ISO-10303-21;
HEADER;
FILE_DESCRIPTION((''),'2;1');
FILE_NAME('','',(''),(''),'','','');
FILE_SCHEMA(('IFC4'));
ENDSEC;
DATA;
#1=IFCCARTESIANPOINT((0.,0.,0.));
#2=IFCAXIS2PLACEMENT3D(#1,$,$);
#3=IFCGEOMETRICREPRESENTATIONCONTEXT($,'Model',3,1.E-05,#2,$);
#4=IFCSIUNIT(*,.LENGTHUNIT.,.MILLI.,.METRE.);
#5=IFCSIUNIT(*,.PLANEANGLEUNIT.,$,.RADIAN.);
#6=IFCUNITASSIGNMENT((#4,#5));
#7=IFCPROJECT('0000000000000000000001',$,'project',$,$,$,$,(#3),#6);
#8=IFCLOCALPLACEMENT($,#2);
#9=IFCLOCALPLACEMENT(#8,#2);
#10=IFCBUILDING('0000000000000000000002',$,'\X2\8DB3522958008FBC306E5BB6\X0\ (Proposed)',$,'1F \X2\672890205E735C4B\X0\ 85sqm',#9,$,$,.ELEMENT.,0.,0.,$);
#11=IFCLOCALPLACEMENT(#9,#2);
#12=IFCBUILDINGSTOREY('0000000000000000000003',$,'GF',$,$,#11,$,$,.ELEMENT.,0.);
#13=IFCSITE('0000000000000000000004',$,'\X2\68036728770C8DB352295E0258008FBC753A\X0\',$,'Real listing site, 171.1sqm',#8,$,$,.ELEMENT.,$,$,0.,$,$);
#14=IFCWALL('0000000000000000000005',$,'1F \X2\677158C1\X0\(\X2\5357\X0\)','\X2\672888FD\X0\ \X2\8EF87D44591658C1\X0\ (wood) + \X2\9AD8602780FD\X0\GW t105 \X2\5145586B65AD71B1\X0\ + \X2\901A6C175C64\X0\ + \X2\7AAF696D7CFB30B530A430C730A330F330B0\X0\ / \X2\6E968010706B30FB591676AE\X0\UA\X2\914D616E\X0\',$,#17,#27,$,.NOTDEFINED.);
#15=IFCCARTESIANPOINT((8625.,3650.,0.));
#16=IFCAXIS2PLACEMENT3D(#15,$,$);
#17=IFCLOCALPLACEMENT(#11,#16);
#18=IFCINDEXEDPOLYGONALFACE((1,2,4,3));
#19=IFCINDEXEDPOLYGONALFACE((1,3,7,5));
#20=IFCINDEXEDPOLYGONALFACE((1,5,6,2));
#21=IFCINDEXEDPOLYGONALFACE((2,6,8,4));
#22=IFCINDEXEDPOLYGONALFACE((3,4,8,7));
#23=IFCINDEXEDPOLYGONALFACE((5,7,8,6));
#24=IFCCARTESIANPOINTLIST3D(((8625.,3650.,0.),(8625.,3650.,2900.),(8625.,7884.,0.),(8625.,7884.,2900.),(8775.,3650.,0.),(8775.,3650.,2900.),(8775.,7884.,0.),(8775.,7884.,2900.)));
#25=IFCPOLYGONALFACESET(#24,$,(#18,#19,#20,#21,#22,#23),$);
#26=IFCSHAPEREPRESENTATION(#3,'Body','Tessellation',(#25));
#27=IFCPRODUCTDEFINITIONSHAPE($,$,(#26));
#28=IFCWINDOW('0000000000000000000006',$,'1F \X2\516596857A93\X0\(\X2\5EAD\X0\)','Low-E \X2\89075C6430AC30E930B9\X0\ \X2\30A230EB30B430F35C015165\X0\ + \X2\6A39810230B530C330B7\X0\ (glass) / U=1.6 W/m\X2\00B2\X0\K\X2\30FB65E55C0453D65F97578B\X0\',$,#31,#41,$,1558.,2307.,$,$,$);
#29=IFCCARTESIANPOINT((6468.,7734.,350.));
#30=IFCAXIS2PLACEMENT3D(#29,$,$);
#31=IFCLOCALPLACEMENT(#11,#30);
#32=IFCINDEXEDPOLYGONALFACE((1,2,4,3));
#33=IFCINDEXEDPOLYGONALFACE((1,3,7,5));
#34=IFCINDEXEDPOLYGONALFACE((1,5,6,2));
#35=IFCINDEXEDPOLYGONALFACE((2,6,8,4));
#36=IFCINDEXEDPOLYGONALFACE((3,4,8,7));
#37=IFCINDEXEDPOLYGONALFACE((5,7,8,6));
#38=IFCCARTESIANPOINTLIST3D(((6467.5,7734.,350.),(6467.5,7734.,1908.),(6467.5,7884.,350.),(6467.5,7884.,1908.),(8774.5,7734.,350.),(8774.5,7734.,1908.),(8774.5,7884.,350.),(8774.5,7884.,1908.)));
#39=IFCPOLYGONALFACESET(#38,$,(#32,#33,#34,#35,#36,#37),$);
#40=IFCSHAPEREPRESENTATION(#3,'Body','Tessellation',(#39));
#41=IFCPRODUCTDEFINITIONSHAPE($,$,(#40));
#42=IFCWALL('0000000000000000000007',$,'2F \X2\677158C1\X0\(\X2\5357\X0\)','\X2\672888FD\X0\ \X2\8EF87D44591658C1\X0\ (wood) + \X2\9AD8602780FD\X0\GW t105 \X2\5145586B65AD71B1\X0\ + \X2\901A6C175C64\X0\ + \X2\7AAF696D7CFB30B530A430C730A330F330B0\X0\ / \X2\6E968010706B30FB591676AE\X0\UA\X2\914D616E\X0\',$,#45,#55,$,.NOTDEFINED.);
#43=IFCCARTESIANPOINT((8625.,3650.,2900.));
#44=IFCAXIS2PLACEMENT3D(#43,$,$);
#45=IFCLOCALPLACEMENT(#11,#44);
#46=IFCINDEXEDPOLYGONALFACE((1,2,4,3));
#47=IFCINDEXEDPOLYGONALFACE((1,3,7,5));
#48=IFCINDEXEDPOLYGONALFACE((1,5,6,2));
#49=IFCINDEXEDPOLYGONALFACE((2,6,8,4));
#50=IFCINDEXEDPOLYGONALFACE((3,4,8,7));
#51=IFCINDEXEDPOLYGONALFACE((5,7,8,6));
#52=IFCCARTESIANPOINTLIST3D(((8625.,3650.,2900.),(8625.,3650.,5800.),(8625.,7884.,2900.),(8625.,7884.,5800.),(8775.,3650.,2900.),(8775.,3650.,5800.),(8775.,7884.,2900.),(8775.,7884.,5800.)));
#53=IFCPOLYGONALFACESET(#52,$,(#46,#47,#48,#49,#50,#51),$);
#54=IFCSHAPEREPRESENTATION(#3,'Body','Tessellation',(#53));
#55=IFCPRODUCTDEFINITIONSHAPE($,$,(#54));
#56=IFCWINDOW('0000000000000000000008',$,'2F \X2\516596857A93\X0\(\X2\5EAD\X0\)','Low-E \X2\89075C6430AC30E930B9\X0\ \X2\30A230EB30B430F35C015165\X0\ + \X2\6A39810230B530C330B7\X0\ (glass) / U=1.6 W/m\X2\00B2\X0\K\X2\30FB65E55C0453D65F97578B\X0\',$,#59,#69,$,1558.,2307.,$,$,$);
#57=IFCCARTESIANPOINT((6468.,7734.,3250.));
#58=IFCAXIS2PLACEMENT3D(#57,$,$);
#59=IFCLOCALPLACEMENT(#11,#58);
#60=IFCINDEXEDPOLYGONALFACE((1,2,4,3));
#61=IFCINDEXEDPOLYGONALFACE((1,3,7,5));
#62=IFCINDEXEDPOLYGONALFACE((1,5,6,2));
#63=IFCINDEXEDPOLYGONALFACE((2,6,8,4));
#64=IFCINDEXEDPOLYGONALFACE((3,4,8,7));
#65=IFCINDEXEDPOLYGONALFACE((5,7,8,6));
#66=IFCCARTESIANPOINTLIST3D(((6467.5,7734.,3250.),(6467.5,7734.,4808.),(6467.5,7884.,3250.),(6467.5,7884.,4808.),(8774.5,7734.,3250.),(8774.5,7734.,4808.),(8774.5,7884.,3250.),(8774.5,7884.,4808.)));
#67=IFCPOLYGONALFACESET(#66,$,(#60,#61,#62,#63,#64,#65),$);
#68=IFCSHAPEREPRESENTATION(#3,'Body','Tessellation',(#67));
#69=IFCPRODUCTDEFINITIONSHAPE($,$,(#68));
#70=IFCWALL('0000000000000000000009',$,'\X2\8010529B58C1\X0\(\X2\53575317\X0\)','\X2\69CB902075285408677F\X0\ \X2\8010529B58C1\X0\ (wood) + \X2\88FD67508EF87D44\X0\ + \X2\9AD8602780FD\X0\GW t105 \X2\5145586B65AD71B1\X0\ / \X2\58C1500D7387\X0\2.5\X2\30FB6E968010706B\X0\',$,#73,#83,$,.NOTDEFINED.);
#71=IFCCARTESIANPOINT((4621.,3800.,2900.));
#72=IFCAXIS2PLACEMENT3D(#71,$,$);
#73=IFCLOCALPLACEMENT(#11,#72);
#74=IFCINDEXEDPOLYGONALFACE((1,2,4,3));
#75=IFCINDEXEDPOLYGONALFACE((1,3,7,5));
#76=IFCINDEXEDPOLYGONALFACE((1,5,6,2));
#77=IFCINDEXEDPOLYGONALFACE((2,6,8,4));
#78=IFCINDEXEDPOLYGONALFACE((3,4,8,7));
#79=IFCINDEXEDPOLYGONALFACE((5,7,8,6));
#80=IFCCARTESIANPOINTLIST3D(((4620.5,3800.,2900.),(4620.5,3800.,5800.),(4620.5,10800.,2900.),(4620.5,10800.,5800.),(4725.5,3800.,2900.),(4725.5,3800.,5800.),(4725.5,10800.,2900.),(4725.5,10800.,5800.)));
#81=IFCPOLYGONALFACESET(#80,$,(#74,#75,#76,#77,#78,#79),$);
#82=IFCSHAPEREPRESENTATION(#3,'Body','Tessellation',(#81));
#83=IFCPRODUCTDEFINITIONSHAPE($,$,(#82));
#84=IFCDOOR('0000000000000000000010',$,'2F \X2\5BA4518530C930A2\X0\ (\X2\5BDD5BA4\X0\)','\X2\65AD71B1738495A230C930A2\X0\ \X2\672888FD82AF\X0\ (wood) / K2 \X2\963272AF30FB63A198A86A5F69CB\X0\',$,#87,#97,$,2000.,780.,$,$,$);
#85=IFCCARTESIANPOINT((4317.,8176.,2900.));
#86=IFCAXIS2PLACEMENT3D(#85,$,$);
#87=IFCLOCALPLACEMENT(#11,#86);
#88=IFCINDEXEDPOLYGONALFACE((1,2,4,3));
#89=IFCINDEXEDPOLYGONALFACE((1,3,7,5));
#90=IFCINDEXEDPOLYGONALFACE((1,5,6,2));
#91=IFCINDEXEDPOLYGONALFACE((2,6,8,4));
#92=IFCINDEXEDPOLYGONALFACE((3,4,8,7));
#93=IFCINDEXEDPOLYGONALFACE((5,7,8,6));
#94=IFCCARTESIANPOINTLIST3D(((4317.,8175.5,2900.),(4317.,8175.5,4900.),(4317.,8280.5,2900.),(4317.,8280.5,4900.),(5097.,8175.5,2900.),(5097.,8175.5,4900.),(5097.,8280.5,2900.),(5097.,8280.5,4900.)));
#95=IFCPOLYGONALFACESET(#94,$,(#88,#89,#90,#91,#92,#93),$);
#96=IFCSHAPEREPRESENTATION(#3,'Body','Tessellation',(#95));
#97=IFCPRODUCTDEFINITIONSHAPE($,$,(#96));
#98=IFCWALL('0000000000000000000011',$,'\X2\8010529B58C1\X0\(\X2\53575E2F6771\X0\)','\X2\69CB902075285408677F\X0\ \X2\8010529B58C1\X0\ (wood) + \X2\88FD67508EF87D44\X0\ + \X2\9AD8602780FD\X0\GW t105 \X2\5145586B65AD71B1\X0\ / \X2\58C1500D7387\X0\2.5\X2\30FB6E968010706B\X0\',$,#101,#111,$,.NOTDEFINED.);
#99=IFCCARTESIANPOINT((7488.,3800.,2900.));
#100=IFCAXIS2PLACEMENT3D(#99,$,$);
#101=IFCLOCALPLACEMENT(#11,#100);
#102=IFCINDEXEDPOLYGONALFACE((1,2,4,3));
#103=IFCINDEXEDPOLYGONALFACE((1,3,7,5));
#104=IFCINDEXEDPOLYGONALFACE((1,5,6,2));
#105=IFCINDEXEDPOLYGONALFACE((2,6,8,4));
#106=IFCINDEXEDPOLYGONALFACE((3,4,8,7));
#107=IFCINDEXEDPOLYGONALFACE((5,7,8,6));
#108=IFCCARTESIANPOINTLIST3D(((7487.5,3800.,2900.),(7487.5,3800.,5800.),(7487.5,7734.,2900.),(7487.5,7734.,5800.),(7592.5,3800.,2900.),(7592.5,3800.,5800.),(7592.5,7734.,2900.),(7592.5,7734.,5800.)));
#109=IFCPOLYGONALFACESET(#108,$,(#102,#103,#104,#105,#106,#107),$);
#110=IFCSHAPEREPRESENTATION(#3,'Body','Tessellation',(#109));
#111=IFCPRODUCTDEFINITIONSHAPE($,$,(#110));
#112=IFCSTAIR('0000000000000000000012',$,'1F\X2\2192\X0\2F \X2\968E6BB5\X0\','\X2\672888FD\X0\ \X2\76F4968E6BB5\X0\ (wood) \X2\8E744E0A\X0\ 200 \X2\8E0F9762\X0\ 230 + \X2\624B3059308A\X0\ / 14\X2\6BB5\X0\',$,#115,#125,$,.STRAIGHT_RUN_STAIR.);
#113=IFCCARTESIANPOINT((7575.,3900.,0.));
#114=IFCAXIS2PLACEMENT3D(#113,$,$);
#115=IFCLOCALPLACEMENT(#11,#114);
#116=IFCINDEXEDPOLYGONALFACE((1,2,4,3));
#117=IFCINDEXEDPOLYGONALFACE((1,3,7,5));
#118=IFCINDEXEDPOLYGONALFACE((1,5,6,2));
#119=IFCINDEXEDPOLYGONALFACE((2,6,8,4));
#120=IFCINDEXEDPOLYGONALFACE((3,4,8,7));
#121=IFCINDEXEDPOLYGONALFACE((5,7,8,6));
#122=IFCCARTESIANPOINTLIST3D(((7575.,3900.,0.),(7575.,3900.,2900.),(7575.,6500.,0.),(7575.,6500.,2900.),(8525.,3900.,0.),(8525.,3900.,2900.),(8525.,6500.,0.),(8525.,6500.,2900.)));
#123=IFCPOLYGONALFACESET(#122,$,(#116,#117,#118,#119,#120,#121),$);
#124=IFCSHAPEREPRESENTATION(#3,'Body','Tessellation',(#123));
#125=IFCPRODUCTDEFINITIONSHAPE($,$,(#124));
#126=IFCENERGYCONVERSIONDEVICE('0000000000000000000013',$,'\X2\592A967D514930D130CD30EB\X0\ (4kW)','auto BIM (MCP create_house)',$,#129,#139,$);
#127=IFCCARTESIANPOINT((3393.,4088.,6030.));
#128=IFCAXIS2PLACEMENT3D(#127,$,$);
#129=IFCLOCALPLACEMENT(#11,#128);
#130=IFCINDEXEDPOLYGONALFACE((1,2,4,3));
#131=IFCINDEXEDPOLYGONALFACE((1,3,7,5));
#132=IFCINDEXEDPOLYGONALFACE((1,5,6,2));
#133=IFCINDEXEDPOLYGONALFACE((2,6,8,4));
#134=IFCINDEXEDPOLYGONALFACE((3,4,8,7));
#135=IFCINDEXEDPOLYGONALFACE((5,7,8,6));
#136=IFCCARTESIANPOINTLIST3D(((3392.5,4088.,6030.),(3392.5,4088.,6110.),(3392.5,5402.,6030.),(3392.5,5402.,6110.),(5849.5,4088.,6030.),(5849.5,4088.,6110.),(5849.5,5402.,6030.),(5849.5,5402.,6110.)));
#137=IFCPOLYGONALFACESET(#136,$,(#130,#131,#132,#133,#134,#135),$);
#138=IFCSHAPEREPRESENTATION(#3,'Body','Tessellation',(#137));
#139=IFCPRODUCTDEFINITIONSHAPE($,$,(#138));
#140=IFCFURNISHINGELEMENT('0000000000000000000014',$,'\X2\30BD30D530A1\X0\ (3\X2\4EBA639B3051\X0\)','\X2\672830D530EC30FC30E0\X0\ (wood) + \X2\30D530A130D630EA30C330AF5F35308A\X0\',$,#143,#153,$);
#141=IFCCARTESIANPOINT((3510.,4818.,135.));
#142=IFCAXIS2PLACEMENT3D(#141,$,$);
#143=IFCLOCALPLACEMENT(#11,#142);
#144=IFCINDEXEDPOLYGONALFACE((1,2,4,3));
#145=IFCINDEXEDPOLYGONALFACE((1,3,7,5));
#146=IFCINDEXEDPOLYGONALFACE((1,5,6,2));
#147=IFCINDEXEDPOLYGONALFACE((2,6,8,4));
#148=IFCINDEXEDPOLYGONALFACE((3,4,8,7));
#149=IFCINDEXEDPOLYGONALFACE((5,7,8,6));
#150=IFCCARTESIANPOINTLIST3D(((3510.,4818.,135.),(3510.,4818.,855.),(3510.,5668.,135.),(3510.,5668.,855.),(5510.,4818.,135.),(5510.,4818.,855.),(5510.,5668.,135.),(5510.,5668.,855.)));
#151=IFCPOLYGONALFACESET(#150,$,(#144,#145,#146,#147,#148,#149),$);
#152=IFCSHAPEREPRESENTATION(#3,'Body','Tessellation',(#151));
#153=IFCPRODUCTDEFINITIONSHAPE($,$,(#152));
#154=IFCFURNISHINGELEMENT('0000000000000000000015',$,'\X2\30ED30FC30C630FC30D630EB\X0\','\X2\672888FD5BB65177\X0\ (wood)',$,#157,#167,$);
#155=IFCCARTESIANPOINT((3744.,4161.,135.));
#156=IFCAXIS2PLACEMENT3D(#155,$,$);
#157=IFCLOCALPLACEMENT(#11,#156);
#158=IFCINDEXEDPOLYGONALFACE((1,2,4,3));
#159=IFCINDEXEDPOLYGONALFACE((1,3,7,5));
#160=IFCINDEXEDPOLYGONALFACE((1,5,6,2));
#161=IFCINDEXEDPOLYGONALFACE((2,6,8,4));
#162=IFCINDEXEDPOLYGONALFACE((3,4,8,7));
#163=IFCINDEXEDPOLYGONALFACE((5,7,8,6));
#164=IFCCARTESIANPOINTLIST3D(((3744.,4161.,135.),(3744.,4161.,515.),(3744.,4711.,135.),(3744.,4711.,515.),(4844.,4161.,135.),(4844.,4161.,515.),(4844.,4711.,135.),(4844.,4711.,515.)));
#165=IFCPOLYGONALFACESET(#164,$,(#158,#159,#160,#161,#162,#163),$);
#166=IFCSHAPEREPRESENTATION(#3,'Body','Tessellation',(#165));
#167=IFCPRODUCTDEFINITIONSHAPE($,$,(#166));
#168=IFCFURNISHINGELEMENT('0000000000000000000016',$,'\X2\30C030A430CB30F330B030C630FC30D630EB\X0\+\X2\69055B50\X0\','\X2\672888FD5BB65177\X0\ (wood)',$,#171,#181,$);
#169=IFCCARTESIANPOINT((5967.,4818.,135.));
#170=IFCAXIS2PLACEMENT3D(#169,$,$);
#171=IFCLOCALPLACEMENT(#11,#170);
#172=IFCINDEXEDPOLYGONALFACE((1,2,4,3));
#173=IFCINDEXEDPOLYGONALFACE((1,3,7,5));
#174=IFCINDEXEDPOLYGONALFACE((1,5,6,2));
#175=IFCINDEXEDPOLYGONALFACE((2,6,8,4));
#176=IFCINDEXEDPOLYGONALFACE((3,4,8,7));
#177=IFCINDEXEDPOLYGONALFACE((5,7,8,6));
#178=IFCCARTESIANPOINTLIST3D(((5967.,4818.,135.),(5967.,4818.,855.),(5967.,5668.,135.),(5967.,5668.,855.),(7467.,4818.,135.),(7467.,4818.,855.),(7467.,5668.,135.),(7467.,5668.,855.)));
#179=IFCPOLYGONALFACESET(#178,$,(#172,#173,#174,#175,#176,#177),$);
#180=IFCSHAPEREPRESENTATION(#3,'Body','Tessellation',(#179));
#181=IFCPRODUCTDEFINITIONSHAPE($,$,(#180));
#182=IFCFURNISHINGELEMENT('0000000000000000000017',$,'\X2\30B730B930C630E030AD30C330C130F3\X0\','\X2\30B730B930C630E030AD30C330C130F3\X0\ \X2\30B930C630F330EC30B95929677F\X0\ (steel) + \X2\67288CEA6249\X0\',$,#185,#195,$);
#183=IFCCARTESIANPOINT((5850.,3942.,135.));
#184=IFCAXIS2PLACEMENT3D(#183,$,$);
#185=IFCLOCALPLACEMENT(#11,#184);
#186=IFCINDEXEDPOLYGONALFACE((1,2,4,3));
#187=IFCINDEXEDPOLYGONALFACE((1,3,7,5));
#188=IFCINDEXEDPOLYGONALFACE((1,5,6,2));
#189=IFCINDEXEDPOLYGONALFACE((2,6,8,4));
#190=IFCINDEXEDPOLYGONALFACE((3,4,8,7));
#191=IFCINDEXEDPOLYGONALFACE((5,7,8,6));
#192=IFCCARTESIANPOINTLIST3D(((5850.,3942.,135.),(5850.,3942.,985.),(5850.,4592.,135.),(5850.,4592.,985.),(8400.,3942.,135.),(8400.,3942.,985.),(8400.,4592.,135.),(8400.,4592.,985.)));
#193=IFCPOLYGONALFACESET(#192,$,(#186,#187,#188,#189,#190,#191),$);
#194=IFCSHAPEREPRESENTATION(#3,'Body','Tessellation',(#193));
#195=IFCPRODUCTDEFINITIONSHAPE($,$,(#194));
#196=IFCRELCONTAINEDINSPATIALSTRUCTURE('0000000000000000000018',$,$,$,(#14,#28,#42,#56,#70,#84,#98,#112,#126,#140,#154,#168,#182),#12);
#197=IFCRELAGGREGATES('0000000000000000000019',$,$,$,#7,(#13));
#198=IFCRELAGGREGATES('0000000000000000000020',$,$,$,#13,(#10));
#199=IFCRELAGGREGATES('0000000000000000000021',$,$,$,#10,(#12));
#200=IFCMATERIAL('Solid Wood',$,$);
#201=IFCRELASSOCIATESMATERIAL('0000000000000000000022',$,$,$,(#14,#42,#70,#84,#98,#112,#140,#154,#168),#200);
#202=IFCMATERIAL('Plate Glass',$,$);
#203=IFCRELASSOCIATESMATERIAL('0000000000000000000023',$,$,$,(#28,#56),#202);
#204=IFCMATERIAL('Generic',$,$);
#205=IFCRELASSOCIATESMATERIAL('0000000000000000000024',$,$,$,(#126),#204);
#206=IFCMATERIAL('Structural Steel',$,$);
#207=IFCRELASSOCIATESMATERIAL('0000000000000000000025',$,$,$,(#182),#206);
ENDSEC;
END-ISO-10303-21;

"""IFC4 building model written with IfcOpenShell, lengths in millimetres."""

from ifc_helpers import new_model, si_unit, frame, frame_2d, origin, place, context, project, spatial, rectangle, extrude, material, element, fill, save


model = new_model("IFC4")

# Units and contexts
model_context = context("Model", 3, precision=1e-05, world=origin())
ifc_project = project(units=[si_unit("LENGTHUNIT", "METRE", prefix="MILLI"), si_unit("PLANEANGLEUNIT", "RADIAN")], contexts=[model_context])

# Site, building, storey
site_placement = place(None, origin())
site = spatial("IfcSite", under=ifc_project, at=site_placement, Name="栃木県足利市堀込町", ObjectType="Real listing site, 171.1sqm", CompositionType="ELEMENT", RefElevation=0.0)
building_placement = place(site_placement, origin())
building = spatial("IfcBuilding", under=site, at=building_placement, Name="足利堀込の家 (Proposed)", ObjectType="1F 木造平屋 85sqm", CompositionType="ELEMENT", ElevationOfRefHeight=0.0, ElevationOfTerrain=0.0)
storey_placement = place(building_placement, origin())
storey = spatial("IfcBuildingStorey", under=building, at=storey_placement, Name="GF", CompositionType="ELEMENT", Elevation=0.0)

# Wall, opening, window
ifc_material_1 = material(Name="Solid Wood")
wall_1_placement = place(storey_placement, frame((8625.0, 3650.0, 0.0)))
wall_1 = element("IfcWall", 1, at=wall_1_placement, inside=storey, material=ifc_material_1, Name="1F 東壁(南)", Description="木製 軸組外壁 (wood) + 高性能GW t105 充填断熱 + 通気層 + 窯業系サイディング / 準耐火・外皮UA配慮", PredefinedType="NOTDEFINED", context=model_context, shape_type="SweptSolid", body=[
    extrude(rectangle(XDim=150.0, YDim=4234.0, at=frame_2d((75.0, 2117.0))), frame((8625.0, 3650.0, 0.0)), (0.0, 0.0, 1.0), 2900.0),
])
opening_1_placement = place(storey_placement, frame((6468.0, 7734.0, 350.0)))
opening_1 = element("IfcOpeningElement", 2, at=opening_1_placement, cuts=wall_1, PredefinedType="NOTDEFINED", context=model_context, shape_type="SweptSolid", body=[
    extrude(rectangle(XDim=2307.0, YDim=150.0, at=frame_2d((1153.0, 75.0))), frame((6468.0, 7734.0, 350.0)), (0.0, 0.0, 1.0), 1558.0),
])
ifc_material_2 = material(Name="Plate Glass")
window_1_placement = place(storey_placement, frame((6468.0, 7734.0, 350.0)))
window_1 = element("IfcWindow", 3, at=window_1_placement, inside=storey, material=ifc_material_2, Name="1F 入隅窓(庭)", Description="Low-E 複層ガラス アルゴン封入 + 樹脂サッシ (glass) / U=1.6 W/m²K・日射取得型", OverallHeight=1558.0, OverallWidth=2307.0, context=model_context, shape_type="SweptSolid", body=[
    extrude(rectangle(XDim=2307.0, YDim=150.0, at=frame_2d((1153.0, 75.0))), frame((6468.0, 7734.0, 350.0)), (0.0, 0.0, 1.0), 1558.0),
])
fill(opening_1, window_1)

# Wall, opening, window
wall_2_placement = place(storey_placement, frame((8625.0, 3650.0, 2900.0)))
wall_2 = element("IfcWall", 4, at=wall_2_placement, inside=storey, material=ifc_material_1, Name="2F 東壁(南)", Description="木製 軸組外壁 (wood) + 高性能GW t105 充填断熱 + 通気層 + 窯業系サイディング / 準耐火・外皮UA配慮", PredefinedType="NOTDEFINED", context=model_context, shape_type="SweptSolid", body=[
    extrude(rectangle(XDim=150.0, YDim=4234.0, at=frame_2d((75.0, 2117.0))), frame((8625.0, 3650.0, 2900.0)), (0.0, 0.0, 1.0), 2900.0),
])
opening_2_placement = place(storey_placement, frame((6468.0, 7734.0, 3250.0)))
opening_2 = element("IfcOpeningElement", 5, at=opening_2_placement, cuts=wall_2, PredefinedType="NOTDEFINED", context=model_context, shape_type="SweptSolid", body=[
    extrude(rectangle(XDim=2307.0, YDim=150.0, at=frame_2d((1153.0, 75.0))), frame((6468.0, 7734.0, 3250.0)), (0.0, 0.0, 1.0), 1558.0),
])
window_2_placement = place(storey_placement, frame((6468.0, 7734.0, 3250.0)))
window_2 = element("IfcWindow", 6, at=window_2_placement, inside=storey, material=ifc_material_2, Name="2F 入隅窓(庭)", Description="Low-E 複層ガラス アルゴン封入 + 樹脂サッシ (glass) / U=1.6 W/m²K・日射取得型", OverallHeight=1558.0, OverallWidth=2307.0, context=model_context, shape_type="SweptSolid", body=[
    extrude(rectangle(XDim=2307.0, YDim=150.0, at=frame_2d((1153.0, 75.0))), frame((6468.0, 7734.0, 3250.0)), (0.0, 0.0, 1.0), 1558.0),
])
fill(opening_2, window_2)

# Wall, opening, door
wall_3_placement = place(storey_placement, frame((4621.0, 3800.0, 2900.0)))
wall_3 = element("IfcWall", 7, at=wall_3_placement, inside=storey, material=ifc_material_1, Name="耐力壁(南北)", Description="構造用合板 耐力壁 (wood) + 製材軸組 + 高性能GW t105 充填断熱 / 壁倍率2.5・準耐火", PredefinedType="NOTDEFINED", context=model_context, shape_type="SweptSolid", body=[
    extrude(rectangle(XDim=105.0, YDim=7000.0, at=frame_2d((52.0, 3500.0))), frame((4621.0, 3800.0, 2900.0)), (0.0, 0.0, 1.0), 2900.0),
])
opening_3_placement = place(storey_placement, frame((4317.0, 8176.0, 2900.0)))
opening_3 = element("IfcOpeningElement", 8, at=opening_3_placement, cuts=wall_3, PredefinedType="NOTDEFINED", context=model_context, shape_type="SweptSolid", body=[
    extrude(rectangle(XDim=780.0, YDim=105.0, at=frame_2d((390.0, 52.0))), frame((4317.0, 8176.0, 2900.0)), (0.0, 0.0, 1.0), 2000.0),
])
door_1_placement = place(storey_placement, frame((4317.0, 8176.0, 2900.0)))
door_1 = element("IfcDoor", 9, at=door_1_placement, inside=storey, material=ifc_material_1, Name="2F 室内ドア (寝室)", Description="断熱玄関ドア 木製芯 (wood) / K2 防犯・採風機構", OverallHeight=2000.0, OverallWidth=780.0, context=model_context, shape_type="SweptSolid", body=[
    extrude(rectangle(XDim=780.0, YDim=105.0, at=frame_2d((390.0, 52.0))), frame((4317.0, 8176.0, 2900.0)), (0.0, 0.0, 1.0), 2000.0),
])
fill(opening_3, door_1)

# Wall
wall_4_placement = place(storey_placement, frame((7488.0, 3800.0, 2900.0)))
element("IfcWall", 10, at=wall_4_placement, inside=storey, material=ifc_material_1, Name="耐力壁(南帯東)", Description="構造用合板 耐力壁 (wood) + 製材軸組 + 高性能GW t105 充填断熱 / 壁倍率2.5・準耐火", PredefinedType="NOTDEFINED", context=model_context, shape_type="SweptSolid", body=[
    extrude(rectangle(XDim=105.0, YDim=3934.0, at=frame_2d((52.0, 1967.0))), frame((7488.0, 3800.0, 2900.0)), (0.0, 0.0, 1.0), 2900.0),
])

# Stair
stair_placement = place(storey_placement, frame((7575.0, 3900.0, 0.0)))
element("IfcStair", 11, at=stair_placement, inside=storey, material=ifc_material_1, Name="1F→2F 階段", Description="木製 直階段 (wood) 蹴上 200 踏面 230 + 手すり / 14段", PredefinedType="STRAIGHT_RUN_STAIR", context=model_context, shape_type="SweptSolid", body=[
    extrude(rectangle(XDim=950.0, YDim=2600.0, at=frame_2d((475.0, 1300.0))), frame((7575.0, 3900.0, 0.0)), (0.0, 0.0, 1.0), 2900.0),
])

# Energy conversion device
ifc_material_3 = material(Name="Generic")
energy_conversion_device_placement = place(storey_placement, frame((3393.0, 4088.0, 6030.0)))
element("IfcEnergyConversionDevice", 12, at=energy_conversion_device_placement, inside=storey, material=ifc_material_3, Name="太陽光パネル (4kW)", Description="auto BIM (MCP create_house)", context=model_context, shape_type="SweptSolid", body=[
    extrude(rectangle(XDim=2457.0, YDim=1314.0, at=frame_2d((1228.0, 657.0))), frame((3393.0, 4088.0, 6030.0)), (0.0, 0.0, 1.0), 80.0),
])

# Furnishing elements
furnishing_1_placement = place(storey_placement, frame((3510.0, 4818.0, 135.0)))
element("IfcFurnishingElement", 13, at=furnishing_1_placement, inside=storey, material=ifc_material_1, Name="ソファ (3人掛け)", Description="木フレーム (wood) + ファブリック張り", context=model_context, shape_type="SweptSolid", body=[
    extrude(rectangle(XDim=2000.0, YDim=850.0, at=frame_2d((1000.0, 425.0))), frame((3510.0, 4818.0, 135.0)), (0.0, 0.0, 1.0), 720.0),
])
furnishing_2_placement = place(storey_placement, frame((3744.0, 4161.0, 135.0)))
element("IfcFurnishingElement", 14, at=furnishing_2_placement, inside=storey, material=ifc_material_1, Name="ローテーブル", Description="木製家具 (wood)", context=model_context, shape_type="SweptSolid", body=[
    extrude(rectangle(XDim=1100.0, YDim=550.0, at=frame_2d((550.0, 275.0))), frame((3744.0, 4161.0, 135.0)), (0.0, 0.0, 1.0), 380.0),
])
furnishing_3_placement = place(storey_placement, frame((5967.0, 4818.0, 135.0)))
element("IfcFurnishingElement", 15, at=furnishing_3_placement, inside=storey, material=ifc_material_1, Name="ダイニングテーブル+椅子", Description="木製家具 (wood)", context=model_context, shape_type="SweptSolid", body=[
    extrude(rectangle(XDim=1500.0, YDim=850.0, at=frame_2d((750.0, 425.0))), frame((5967.0, 4818.0, 135.0)), (0.0, 0.0, 1.0), 720.0),
])
ifc_material_4 = material(Name="Structural Steel")
furnishing_4_placement = place(storey_placement, frame((5850.0, 3942.0, 135.0)))
element("IfcFurnishingElement", 16, at=furnishing_4_placement, inside=storey, material=ifc_material_4, Name="システムキッチン", Description="システムキッチン ステンレス天板 (steel) + 木質扉", context=model_context, shape_type="SweptSolid", body=[
    extrude(rectangle(XDim=2550.0, YDim=650.0, at=frame_2d((1275.0, 325.0))), frame((5850.0, 3942.0, 135.0)), (0.0, 0.0, 1.0), 850.0),
])

save(model, "model.ifc")
